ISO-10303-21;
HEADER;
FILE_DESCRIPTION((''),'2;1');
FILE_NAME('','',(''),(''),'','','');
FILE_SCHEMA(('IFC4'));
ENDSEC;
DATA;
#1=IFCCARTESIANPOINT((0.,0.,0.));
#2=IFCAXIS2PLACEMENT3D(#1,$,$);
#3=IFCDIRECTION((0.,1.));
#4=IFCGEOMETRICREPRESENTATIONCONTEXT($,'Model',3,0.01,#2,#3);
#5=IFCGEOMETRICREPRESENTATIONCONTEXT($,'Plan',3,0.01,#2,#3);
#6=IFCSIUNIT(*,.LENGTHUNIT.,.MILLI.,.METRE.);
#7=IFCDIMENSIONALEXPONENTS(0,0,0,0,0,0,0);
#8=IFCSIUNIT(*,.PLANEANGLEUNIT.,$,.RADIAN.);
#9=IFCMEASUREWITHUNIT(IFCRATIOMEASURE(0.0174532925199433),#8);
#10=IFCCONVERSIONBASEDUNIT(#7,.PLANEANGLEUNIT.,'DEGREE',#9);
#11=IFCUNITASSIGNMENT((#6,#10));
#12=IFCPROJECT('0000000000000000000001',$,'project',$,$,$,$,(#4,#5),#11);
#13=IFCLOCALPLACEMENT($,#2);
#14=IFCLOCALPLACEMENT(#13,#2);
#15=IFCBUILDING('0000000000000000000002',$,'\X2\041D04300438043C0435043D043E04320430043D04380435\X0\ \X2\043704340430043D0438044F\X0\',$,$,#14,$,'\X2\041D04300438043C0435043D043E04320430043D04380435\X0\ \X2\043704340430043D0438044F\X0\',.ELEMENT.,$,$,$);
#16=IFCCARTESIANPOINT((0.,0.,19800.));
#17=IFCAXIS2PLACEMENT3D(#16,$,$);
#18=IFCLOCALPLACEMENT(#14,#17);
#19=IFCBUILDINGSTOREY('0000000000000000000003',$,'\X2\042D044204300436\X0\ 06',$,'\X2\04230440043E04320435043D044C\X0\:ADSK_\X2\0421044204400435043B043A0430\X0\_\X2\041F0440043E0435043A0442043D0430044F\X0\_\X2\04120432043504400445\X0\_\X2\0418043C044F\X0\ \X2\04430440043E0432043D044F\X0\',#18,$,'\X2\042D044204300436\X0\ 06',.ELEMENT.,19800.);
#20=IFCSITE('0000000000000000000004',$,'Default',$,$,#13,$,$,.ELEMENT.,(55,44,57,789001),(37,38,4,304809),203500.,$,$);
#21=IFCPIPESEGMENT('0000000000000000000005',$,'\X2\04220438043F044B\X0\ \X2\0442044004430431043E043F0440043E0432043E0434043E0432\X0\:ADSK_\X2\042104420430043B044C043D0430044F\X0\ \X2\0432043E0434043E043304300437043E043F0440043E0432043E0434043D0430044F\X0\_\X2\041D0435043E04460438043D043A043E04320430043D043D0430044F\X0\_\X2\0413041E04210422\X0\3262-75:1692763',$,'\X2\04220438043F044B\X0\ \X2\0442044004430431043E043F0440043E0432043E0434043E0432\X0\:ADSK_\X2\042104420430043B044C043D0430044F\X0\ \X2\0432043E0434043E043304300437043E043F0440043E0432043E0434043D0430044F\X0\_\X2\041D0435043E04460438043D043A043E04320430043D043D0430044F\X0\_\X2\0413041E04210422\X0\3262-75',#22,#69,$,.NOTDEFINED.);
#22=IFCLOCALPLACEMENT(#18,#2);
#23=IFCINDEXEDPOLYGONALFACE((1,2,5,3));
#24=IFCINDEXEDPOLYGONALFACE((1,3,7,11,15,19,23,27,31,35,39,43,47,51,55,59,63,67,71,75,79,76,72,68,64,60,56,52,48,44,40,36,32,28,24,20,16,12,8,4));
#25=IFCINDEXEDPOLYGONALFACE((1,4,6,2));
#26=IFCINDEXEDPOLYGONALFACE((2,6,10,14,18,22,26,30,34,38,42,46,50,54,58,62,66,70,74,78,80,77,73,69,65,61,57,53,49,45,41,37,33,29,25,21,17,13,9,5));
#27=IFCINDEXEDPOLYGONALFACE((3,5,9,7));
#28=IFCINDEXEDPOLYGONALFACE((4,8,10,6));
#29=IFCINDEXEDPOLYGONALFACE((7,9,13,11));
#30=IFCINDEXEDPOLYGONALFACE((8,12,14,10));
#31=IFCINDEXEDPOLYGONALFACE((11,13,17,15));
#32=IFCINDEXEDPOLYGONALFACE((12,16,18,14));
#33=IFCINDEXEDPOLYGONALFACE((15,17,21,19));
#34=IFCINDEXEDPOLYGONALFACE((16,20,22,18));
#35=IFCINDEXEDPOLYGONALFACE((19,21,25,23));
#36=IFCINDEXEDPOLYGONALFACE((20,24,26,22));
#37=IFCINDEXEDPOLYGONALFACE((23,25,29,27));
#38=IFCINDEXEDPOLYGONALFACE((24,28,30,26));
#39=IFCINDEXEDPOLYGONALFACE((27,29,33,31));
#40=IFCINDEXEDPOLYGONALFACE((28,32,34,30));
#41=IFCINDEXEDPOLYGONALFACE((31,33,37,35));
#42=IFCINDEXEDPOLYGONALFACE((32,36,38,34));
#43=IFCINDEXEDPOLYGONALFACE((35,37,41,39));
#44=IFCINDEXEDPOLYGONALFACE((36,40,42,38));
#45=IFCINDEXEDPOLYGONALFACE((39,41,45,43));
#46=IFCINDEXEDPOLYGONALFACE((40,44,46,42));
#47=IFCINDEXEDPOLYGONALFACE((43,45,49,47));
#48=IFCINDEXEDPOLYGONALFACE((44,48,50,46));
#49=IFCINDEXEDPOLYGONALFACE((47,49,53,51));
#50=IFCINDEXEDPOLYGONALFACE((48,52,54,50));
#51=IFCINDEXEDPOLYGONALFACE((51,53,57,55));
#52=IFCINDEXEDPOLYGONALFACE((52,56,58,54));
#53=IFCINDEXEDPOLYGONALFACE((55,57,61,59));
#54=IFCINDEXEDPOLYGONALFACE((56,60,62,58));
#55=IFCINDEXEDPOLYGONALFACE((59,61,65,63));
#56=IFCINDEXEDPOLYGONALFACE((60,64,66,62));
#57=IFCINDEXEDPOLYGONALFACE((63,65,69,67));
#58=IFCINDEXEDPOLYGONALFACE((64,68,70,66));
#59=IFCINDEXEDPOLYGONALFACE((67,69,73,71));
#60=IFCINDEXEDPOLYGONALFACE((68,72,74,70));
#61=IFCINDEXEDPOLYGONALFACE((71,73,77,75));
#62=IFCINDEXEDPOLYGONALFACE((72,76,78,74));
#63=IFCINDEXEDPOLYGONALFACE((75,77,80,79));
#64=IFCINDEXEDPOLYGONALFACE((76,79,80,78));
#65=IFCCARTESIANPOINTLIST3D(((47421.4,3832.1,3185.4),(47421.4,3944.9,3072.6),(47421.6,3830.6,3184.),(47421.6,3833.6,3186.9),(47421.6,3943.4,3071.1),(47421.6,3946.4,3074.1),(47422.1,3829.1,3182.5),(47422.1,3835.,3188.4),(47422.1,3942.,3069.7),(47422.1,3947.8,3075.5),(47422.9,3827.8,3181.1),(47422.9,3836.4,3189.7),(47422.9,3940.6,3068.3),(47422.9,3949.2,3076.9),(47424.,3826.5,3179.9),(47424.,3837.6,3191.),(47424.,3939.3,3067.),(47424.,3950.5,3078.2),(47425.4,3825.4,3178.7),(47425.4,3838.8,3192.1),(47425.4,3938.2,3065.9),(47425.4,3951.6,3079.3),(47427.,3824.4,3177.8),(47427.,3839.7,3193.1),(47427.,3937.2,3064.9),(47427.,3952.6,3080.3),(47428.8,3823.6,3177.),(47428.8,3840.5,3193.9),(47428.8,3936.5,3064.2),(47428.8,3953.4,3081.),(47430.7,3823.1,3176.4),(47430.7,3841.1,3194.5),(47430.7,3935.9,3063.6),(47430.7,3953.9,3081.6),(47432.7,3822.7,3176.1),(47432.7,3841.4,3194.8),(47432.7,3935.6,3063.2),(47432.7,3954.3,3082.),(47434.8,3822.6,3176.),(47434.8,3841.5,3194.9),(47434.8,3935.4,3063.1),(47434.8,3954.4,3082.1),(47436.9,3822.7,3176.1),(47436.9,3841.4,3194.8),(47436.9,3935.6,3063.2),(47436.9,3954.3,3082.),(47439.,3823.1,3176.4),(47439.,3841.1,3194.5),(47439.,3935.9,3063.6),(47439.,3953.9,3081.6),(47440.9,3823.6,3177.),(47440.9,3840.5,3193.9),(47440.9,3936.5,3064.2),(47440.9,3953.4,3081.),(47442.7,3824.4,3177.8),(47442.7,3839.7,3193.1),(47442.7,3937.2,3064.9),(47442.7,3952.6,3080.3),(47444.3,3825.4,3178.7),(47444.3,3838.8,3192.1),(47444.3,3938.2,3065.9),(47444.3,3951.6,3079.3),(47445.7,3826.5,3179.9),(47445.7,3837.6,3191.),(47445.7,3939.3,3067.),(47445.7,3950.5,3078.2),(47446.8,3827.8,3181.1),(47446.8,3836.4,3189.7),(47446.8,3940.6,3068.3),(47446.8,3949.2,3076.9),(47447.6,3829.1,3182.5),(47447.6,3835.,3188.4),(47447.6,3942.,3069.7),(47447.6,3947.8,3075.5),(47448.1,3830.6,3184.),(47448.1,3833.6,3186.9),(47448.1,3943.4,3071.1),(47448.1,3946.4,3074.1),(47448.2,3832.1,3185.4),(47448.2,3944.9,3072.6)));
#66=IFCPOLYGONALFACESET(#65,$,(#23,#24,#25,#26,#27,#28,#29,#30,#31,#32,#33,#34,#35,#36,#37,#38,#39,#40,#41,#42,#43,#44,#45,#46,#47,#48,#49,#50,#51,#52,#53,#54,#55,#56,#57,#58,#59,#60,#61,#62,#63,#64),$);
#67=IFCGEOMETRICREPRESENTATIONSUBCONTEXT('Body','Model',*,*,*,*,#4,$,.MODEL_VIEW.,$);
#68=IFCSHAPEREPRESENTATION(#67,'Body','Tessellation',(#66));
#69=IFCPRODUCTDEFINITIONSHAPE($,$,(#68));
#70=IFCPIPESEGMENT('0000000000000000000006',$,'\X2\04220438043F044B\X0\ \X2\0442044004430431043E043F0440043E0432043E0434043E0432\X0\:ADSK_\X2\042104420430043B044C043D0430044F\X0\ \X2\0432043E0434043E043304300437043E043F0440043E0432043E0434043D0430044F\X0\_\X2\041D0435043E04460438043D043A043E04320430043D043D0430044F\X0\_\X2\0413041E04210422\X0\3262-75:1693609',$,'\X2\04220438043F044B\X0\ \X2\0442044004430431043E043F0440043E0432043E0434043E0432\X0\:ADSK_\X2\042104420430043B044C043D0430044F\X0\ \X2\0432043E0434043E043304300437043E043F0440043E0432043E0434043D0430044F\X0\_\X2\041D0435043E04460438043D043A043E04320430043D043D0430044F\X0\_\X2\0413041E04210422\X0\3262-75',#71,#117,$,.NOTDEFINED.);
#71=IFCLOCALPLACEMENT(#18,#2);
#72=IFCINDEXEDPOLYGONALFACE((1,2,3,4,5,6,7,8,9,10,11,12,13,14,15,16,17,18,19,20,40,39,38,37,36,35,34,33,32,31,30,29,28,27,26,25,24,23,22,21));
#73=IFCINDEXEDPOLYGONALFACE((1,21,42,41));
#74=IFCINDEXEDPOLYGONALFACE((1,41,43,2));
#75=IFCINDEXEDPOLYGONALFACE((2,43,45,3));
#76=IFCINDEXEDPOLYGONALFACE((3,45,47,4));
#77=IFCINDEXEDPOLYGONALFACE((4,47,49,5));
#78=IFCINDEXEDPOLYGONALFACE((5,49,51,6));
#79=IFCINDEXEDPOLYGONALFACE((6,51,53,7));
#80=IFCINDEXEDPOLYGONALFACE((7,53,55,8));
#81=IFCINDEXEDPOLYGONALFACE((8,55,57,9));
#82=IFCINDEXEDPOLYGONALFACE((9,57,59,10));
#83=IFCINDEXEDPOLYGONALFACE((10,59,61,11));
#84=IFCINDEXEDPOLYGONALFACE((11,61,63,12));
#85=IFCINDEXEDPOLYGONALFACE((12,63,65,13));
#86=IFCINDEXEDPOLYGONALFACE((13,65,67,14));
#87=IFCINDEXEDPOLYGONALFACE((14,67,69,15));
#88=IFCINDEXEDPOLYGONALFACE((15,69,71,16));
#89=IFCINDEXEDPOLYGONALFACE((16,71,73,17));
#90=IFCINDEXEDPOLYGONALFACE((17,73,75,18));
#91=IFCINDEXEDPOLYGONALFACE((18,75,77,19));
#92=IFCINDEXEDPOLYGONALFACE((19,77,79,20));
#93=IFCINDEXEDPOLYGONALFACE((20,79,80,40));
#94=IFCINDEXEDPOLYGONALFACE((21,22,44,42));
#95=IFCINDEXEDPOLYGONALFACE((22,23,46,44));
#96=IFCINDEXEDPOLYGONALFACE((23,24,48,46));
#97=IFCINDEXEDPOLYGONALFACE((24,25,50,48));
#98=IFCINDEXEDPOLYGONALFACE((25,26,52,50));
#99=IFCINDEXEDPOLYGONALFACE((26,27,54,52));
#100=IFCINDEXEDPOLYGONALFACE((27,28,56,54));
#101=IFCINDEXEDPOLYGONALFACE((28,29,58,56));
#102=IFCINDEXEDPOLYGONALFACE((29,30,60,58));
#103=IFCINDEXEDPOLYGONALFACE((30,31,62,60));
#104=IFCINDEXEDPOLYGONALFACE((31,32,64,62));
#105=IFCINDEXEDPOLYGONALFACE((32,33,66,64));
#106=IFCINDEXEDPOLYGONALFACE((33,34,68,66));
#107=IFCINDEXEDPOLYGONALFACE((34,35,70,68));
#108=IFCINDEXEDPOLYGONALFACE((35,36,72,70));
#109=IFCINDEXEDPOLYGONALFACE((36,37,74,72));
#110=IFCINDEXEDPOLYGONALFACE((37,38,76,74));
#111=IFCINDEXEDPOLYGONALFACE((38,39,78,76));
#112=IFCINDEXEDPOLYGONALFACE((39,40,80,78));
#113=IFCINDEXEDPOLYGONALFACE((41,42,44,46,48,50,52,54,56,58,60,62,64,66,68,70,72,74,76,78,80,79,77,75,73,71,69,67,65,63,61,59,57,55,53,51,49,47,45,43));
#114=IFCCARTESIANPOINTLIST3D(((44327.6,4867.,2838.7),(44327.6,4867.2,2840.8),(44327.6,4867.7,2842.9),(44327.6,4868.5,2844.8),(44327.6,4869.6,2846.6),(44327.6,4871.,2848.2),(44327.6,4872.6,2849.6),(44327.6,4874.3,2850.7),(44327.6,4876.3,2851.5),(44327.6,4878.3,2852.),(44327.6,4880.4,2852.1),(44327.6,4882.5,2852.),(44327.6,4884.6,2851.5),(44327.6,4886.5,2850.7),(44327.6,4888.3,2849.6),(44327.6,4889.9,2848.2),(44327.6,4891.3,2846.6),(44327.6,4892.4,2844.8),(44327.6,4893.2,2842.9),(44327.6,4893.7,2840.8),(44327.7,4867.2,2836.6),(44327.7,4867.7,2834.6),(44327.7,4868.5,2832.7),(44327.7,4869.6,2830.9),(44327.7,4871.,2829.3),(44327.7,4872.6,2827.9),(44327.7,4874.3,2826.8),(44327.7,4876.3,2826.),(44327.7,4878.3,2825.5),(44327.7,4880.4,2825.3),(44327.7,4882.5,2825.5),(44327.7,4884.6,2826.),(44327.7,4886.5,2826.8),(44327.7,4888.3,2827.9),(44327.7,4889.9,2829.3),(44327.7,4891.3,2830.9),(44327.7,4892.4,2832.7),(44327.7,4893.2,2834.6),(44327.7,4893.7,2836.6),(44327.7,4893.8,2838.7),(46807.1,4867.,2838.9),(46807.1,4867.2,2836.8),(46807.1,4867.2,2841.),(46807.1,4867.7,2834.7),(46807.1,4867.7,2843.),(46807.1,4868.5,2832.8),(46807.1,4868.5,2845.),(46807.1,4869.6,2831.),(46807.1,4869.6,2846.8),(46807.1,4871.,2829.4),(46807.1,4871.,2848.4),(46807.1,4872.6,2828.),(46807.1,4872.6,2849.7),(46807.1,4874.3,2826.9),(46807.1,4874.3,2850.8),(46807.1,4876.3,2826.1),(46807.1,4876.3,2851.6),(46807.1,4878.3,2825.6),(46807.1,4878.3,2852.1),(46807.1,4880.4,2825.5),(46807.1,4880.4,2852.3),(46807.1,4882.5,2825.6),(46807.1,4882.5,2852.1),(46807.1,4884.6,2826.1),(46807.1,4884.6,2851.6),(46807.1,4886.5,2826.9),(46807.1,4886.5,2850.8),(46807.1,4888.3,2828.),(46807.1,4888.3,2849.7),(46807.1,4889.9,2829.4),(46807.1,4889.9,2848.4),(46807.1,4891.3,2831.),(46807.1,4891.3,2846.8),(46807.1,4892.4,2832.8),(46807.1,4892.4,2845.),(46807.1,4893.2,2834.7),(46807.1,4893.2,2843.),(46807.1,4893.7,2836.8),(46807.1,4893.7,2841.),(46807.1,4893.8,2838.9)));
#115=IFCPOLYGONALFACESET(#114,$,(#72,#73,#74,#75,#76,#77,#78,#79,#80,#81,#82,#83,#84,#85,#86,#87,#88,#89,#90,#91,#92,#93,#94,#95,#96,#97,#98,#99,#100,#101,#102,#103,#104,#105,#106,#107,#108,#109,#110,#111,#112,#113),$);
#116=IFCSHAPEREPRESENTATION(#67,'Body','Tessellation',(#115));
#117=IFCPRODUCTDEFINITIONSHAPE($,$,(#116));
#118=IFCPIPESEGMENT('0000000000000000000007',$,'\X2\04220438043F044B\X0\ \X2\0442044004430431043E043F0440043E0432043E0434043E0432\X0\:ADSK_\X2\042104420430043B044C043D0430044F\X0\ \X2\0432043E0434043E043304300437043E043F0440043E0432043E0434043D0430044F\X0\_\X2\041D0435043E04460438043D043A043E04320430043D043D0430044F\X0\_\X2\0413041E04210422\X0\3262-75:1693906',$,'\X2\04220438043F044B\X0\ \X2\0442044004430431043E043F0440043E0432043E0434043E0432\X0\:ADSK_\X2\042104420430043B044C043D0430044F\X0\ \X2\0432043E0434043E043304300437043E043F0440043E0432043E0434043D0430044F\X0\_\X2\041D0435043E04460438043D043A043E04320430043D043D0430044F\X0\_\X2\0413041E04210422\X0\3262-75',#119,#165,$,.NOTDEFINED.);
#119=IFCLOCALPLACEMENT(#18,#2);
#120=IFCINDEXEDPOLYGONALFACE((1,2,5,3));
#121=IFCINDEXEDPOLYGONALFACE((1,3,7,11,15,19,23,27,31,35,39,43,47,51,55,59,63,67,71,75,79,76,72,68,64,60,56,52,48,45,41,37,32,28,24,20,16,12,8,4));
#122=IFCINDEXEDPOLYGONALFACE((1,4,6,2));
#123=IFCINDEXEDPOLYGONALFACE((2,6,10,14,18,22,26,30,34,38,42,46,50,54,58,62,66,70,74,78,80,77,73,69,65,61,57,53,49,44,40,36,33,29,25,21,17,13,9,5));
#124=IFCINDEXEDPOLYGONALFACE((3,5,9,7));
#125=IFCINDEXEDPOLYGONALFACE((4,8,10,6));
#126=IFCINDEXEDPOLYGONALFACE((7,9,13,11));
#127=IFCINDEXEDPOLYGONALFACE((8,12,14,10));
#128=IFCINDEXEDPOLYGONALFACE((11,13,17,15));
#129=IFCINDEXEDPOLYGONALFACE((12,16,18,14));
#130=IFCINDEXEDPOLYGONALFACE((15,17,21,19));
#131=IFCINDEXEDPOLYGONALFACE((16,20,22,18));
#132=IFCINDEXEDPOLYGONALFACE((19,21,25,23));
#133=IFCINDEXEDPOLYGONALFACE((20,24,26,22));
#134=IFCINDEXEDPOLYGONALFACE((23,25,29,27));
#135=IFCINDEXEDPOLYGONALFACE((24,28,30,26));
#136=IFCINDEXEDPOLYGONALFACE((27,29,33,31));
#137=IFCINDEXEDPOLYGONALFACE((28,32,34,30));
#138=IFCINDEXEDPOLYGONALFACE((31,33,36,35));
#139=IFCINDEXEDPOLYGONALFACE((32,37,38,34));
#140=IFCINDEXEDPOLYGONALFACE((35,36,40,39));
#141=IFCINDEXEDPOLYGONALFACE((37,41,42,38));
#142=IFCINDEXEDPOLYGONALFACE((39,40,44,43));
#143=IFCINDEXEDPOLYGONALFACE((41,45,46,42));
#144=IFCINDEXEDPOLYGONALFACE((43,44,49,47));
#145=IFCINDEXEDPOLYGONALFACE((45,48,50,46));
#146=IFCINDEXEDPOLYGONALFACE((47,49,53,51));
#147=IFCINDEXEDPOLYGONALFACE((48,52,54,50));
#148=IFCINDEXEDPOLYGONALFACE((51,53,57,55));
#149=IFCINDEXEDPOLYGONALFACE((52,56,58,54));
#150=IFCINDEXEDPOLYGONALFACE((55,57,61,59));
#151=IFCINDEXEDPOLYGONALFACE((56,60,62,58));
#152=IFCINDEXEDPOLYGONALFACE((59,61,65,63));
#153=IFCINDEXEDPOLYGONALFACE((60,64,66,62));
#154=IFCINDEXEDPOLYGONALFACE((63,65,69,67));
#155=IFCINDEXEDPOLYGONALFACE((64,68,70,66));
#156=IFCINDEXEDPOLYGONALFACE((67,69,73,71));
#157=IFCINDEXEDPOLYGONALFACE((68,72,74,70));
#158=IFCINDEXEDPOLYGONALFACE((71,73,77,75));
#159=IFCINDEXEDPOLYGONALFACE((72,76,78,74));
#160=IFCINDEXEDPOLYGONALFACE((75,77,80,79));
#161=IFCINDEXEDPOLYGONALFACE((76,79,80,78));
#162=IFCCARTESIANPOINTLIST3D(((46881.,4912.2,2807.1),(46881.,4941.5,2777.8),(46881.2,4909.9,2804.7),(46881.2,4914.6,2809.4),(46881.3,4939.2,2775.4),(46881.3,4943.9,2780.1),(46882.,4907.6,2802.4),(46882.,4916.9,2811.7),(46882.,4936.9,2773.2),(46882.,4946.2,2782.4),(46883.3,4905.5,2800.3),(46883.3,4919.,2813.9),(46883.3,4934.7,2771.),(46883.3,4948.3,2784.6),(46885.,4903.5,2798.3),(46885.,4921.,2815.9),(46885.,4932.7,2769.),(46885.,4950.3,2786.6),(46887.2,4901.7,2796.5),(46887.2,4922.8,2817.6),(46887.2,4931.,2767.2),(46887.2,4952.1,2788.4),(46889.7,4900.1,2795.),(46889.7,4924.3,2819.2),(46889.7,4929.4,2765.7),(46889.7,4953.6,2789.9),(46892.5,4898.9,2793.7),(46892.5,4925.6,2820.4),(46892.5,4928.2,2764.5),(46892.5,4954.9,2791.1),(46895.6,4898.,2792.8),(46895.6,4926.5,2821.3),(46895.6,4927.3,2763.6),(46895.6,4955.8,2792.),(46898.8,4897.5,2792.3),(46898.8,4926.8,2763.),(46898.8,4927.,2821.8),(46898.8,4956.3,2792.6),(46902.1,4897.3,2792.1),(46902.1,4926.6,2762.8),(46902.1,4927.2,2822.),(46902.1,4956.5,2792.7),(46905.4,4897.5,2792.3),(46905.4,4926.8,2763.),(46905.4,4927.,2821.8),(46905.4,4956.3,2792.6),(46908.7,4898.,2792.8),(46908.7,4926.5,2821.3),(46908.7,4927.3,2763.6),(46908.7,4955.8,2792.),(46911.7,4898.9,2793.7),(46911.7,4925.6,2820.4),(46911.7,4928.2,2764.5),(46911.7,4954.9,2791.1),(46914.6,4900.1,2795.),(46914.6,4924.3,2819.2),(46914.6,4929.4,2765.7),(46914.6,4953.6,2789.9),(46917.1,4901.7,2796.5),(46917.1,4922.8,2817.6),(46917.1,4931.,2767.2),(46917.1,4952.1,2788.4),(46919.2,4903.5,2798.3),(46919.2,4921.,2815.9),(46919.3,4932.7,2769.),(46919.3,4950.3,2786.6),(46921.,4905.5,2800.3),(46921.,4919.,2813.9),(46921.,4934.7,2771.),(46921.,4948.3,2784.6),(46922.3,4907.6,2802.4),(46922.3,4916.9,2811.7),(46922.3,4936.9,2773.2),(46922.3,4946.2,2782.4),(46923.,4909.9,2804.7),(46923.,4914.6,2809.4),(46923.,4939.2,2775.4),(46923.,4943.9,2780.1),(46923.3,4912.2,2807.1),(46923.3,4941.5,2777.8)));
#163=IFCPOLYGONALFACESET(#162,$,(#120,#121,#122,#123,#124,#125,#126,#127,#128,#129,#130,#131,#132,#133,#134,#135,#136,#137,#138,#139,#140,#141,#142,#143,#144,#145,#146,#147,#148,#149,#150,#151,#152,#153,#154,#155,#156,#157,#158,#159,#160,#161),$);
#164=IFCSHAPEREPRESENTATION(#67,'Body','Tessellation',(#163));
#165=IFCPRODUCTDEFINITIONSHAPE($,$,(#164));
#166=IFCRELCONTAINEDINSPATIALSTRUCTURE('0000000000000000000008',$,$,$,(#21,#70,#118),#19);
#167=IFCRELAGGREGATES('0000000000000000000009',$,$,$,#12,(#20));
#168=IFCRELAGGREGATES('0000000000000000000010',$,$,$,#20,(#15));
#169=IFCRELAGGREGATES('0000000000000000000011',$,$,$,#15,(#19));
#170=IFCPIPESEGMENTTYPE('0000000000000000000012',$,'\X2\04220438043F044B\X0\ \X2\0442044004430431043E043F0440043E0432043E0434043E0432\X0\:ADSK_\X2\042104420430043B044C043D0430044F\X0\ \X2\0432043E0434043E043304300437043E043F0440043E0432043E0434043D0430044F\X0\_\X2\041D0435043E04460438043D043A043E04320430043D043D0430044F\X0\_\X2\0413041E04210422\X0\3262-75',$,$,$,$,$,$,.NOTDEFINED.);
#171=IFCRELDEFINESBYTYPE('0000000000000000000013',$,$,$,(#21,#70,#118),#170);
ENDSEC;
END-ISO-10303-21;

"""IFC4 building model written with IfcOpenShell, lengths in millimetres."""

from ifc_helpers import new_model, entity, si_unit, converted_unit, direction, frame, origin, place, context, subcontext, project, spatial, indexed_curve, outline, extrude, type_object, element, save


model = new_model("IFC4")

# Units and contexts
model_context = context("Model", 3, precision=0.01, world=origin(), true_north=direction((0.0, 1.0)))
plan_context = context("Plan", 3, precision=0.01, world=origin(), true_north=direction((0.0, 1.0)))
body_context = subcontext(model_context, "Body", "Model", "MODEL_VIEW")
ifc_project = project(units=[si_unit("LENGTHUNIT", "METRE", prefix="MILLI"), converted_unit("PLANEANGLEUNIT", "DEGREE", entity("IfcRatioMeasure", 0.0174532925199433), si_unit("PLANEANGLEUNIT", "RADIAN"), dimensions=[0, 0, 0, 0, 0, 0, 0])], contexts=[model_context, plan_context])

# Site, building, storey
site_placement = place(None, origin())
site = spatial("IfcSite", under=ifc_project, at=site_placement, Name="Default", CompositionType="ELEMENT", RefLatitude=(55, 44, 57, 789001), RefLongitude=(37, 38, 4, 304809), RefElevation=203500.0)
building_placement = place(site_placement, origin())
building = spatial("IfcBuilding", under=site, at=building_placement, Name="Наименование здания", LongName="Наименование здания", CompositionType="ELEMENT")
storey_placement = place(building_placement, frame((0.0, 0.0, 19800.0)))
storey = spatial("IfcBuildingStorey", under=building, at=storey_placement, Name="Этаж 06", ObjectType="Уровень:ADSK_Стрелка_Проектная_Вверх_Имя уровня", LongName="Этаж 06", CompositionType="ELEMENT", Elevation=19800.0)

# Pipe segments
pipe_segment_type = type_object("IfcPipeSegmentType", Name="Типы трубопроводов:ADSK_Стальная водогазопроводная_Неоцинкованная_ГОСТ3262-75", PredefinedType="NOTDEFINED")
placement = place(storey_placement, origin())
element("IfcPipeSegment", 1, at=placement, inside=storey, type_object=pipe_segment_type, Name="Типы трубопроводов:ADSK_Стальная водогазопроводная_Неоцинкованная_ГОСТ3262-75:1692763", ObjectType="Типы трубопроводов:ADSK_Стальная водогазопроводная_Неоцинкованная_ГОСТ3262-75", PredefinedType="NOTDEFINED", context=body_context, shape_type="SweptSolid", body=[
    extrude(outline(indexed_curve([(13.4, 0.0), (13.2, 2.1), (12.7, 4.1), (11.9, 6.1), (10.8, 7.9), (9.5, 9.5), (7.9, 10.8), (6.1, 11.9), (4.1, 12.7), (2.1, 13.2), (0.0, 13.4), (-2.1, 13.2), (-4.1, 12.7), (-6.1, 11.9), (-7.9, 10.8), (-9.5, 9.5), (-10.8, 7.9), (-11.9, 6.1), (-12.7, 4.1), (-13.2, 2.1), (-13.4, 0.0), (-13.2, -2.1), (-12.7, -4.1), (-11.9, -6.1), (-10.8, -7.9), (-9.5, -9.5), (-7.9, -10.8), (-6.1, -11.9), (-4.1, -12.7), (-2.1, -13.2), (0.0, -13.4), (2.1, -13.2), (4.1, -12.7), (6.1, -11.9), (7.9, -10.8), (9.5, -9.5), (10.8, -7.9), (11.9, -6.1), (12.7, -4.1), (13.2, -2.1), (13.4, 0.0)], self_intersect=False)), frame((47434.8, 3944.9, 3072.6), z_axis=(0.0, -0.707107, 0.707107), x_axis=(-1.0, 0.0, 0.0)), (0.0, 0.0, 1.0), 159.6),
])
element("IfcPipeSegment", 2, at=placement, inside=storey, type_object=pipe_segment_type, Name="Типы трубопроводов:ADSK_Стальная водогазопроводная_Неоцинкованная_ГОСТ3262-75:1693609", ObjectType="Типы трубопроводов:ADSK_Стальная водогазопроводная_Неоцинкованная_ГОСТ3262-75", PredefinedType="NOTDEFINED", context=body_context, shape_type="SweptSolid", body=[
    extrude(outline(indexed_curve([(13.4, 0.0), (13.2, 2.1), (12.7, 4.1), (11.9, 6.1), (10.8, 7.9), (9.5, 9.5), (7.9, 10.8), (6.1, 11.9), (4.1, 12.7), (2.1, 13.2), (0.0, 13.4), (-2.1, 13.2), (-4.1, 12.7), (-6.1, 11.9), (-7.9, 10.8), (-9.5, 9.5), (-10.8, 7.9), (-11.9, 6.1), (-12.7, 4.1), (-13.2, 2.1), (-13.4, 0.0), (-13.2, -2.1), (-12.7, -4.1), (-11.9, -6.1), (-10.8, -7.9), (-9.5, -9.5), (-7.9, -10.8), (-6.1, -11.9), (-4.1, -12.7), (-2.1, -13.2), (0.0, -13.4), (2.1, -13.2), (4.1, -12.7), (6.1, -11.9), (7.9, -10.8), (9.5, -9.5), (10.8, -7.9), (11.9, -6.1), (12.7, -4.1), (13.2, -2.1), (13.4, 0.0)], self_intersect=False)), frame((44327.7, 4880.4, 2838.7), z_axis=(1.0, -0.000001, 0.000058), x_axis=(0.000001, 1.0, 0.0)), (0.0, 0.0, 1.0), 2479.5),
])
element("IfcPipeSegment", 3, at=placement, inside=storey, type_object=pipe_segment_type, Name="Типы трубопроводов:ADSK_Стальная водогазопроводная_Неоцинкованная_ГОСТ3262-75:1693906", ObjectType="Типы трубопроводов:ADSK_Стальная водогазопроводная_Неоцинкованная_ГОСТ3262-75", PredefinedType="NOTDEFINED", context=body_context, shape_type="SweptSolid", body=[
    extrude(outline(indexed_curve([(21.1, 0.0), (20.9, 3.3), (20.1, 6.5), (18.8, 9.6), (17.1, 12.4), (15.0, 15.0), (12.4, 17.1), (9.6, 18.8), (6.5, 20.1), (3.3, 20.9), (0.0, 21.1), (-3.3, 20.9), (-6.5, 20.1), (-9.6, 18.8), (-12.4, 17.1), (-15.0, 15.0), (-17.1, 12.4), (-18.8, 9.6), (-20.1, 6.5), (-20.9, 3.3), (-21.1, 0.0), (-20.9, -3.3), (-20.1, -6.5), (-18.8, -9.6), (-17.1, -12.4), (-15.0, -15.0), (-12.4, -17.1), (-9.6, -18.8), (-6.5, -20.1), (-3.3, -20.9), (0.0, -21.1), (3.3, -20.9), (6.5, -20.1), (9.6, -18.8), (12.4, -17.1), (15.0, -15.0), (17.1, -12.4), (18.8, -9.6), (20.1, -6.5), (20.9, -3.3), (21.1, 0.0)], self_intersect=False)), frame((46902.1, 4941.5, 2777.8), z_axis=(-0.000041, -0.707107, 0.707107), x_axis=(-1.0, 0.000058, 0.0)), (0.0, 0.0, 1.0), 41.4),
])

save(model, "model.ifc")
